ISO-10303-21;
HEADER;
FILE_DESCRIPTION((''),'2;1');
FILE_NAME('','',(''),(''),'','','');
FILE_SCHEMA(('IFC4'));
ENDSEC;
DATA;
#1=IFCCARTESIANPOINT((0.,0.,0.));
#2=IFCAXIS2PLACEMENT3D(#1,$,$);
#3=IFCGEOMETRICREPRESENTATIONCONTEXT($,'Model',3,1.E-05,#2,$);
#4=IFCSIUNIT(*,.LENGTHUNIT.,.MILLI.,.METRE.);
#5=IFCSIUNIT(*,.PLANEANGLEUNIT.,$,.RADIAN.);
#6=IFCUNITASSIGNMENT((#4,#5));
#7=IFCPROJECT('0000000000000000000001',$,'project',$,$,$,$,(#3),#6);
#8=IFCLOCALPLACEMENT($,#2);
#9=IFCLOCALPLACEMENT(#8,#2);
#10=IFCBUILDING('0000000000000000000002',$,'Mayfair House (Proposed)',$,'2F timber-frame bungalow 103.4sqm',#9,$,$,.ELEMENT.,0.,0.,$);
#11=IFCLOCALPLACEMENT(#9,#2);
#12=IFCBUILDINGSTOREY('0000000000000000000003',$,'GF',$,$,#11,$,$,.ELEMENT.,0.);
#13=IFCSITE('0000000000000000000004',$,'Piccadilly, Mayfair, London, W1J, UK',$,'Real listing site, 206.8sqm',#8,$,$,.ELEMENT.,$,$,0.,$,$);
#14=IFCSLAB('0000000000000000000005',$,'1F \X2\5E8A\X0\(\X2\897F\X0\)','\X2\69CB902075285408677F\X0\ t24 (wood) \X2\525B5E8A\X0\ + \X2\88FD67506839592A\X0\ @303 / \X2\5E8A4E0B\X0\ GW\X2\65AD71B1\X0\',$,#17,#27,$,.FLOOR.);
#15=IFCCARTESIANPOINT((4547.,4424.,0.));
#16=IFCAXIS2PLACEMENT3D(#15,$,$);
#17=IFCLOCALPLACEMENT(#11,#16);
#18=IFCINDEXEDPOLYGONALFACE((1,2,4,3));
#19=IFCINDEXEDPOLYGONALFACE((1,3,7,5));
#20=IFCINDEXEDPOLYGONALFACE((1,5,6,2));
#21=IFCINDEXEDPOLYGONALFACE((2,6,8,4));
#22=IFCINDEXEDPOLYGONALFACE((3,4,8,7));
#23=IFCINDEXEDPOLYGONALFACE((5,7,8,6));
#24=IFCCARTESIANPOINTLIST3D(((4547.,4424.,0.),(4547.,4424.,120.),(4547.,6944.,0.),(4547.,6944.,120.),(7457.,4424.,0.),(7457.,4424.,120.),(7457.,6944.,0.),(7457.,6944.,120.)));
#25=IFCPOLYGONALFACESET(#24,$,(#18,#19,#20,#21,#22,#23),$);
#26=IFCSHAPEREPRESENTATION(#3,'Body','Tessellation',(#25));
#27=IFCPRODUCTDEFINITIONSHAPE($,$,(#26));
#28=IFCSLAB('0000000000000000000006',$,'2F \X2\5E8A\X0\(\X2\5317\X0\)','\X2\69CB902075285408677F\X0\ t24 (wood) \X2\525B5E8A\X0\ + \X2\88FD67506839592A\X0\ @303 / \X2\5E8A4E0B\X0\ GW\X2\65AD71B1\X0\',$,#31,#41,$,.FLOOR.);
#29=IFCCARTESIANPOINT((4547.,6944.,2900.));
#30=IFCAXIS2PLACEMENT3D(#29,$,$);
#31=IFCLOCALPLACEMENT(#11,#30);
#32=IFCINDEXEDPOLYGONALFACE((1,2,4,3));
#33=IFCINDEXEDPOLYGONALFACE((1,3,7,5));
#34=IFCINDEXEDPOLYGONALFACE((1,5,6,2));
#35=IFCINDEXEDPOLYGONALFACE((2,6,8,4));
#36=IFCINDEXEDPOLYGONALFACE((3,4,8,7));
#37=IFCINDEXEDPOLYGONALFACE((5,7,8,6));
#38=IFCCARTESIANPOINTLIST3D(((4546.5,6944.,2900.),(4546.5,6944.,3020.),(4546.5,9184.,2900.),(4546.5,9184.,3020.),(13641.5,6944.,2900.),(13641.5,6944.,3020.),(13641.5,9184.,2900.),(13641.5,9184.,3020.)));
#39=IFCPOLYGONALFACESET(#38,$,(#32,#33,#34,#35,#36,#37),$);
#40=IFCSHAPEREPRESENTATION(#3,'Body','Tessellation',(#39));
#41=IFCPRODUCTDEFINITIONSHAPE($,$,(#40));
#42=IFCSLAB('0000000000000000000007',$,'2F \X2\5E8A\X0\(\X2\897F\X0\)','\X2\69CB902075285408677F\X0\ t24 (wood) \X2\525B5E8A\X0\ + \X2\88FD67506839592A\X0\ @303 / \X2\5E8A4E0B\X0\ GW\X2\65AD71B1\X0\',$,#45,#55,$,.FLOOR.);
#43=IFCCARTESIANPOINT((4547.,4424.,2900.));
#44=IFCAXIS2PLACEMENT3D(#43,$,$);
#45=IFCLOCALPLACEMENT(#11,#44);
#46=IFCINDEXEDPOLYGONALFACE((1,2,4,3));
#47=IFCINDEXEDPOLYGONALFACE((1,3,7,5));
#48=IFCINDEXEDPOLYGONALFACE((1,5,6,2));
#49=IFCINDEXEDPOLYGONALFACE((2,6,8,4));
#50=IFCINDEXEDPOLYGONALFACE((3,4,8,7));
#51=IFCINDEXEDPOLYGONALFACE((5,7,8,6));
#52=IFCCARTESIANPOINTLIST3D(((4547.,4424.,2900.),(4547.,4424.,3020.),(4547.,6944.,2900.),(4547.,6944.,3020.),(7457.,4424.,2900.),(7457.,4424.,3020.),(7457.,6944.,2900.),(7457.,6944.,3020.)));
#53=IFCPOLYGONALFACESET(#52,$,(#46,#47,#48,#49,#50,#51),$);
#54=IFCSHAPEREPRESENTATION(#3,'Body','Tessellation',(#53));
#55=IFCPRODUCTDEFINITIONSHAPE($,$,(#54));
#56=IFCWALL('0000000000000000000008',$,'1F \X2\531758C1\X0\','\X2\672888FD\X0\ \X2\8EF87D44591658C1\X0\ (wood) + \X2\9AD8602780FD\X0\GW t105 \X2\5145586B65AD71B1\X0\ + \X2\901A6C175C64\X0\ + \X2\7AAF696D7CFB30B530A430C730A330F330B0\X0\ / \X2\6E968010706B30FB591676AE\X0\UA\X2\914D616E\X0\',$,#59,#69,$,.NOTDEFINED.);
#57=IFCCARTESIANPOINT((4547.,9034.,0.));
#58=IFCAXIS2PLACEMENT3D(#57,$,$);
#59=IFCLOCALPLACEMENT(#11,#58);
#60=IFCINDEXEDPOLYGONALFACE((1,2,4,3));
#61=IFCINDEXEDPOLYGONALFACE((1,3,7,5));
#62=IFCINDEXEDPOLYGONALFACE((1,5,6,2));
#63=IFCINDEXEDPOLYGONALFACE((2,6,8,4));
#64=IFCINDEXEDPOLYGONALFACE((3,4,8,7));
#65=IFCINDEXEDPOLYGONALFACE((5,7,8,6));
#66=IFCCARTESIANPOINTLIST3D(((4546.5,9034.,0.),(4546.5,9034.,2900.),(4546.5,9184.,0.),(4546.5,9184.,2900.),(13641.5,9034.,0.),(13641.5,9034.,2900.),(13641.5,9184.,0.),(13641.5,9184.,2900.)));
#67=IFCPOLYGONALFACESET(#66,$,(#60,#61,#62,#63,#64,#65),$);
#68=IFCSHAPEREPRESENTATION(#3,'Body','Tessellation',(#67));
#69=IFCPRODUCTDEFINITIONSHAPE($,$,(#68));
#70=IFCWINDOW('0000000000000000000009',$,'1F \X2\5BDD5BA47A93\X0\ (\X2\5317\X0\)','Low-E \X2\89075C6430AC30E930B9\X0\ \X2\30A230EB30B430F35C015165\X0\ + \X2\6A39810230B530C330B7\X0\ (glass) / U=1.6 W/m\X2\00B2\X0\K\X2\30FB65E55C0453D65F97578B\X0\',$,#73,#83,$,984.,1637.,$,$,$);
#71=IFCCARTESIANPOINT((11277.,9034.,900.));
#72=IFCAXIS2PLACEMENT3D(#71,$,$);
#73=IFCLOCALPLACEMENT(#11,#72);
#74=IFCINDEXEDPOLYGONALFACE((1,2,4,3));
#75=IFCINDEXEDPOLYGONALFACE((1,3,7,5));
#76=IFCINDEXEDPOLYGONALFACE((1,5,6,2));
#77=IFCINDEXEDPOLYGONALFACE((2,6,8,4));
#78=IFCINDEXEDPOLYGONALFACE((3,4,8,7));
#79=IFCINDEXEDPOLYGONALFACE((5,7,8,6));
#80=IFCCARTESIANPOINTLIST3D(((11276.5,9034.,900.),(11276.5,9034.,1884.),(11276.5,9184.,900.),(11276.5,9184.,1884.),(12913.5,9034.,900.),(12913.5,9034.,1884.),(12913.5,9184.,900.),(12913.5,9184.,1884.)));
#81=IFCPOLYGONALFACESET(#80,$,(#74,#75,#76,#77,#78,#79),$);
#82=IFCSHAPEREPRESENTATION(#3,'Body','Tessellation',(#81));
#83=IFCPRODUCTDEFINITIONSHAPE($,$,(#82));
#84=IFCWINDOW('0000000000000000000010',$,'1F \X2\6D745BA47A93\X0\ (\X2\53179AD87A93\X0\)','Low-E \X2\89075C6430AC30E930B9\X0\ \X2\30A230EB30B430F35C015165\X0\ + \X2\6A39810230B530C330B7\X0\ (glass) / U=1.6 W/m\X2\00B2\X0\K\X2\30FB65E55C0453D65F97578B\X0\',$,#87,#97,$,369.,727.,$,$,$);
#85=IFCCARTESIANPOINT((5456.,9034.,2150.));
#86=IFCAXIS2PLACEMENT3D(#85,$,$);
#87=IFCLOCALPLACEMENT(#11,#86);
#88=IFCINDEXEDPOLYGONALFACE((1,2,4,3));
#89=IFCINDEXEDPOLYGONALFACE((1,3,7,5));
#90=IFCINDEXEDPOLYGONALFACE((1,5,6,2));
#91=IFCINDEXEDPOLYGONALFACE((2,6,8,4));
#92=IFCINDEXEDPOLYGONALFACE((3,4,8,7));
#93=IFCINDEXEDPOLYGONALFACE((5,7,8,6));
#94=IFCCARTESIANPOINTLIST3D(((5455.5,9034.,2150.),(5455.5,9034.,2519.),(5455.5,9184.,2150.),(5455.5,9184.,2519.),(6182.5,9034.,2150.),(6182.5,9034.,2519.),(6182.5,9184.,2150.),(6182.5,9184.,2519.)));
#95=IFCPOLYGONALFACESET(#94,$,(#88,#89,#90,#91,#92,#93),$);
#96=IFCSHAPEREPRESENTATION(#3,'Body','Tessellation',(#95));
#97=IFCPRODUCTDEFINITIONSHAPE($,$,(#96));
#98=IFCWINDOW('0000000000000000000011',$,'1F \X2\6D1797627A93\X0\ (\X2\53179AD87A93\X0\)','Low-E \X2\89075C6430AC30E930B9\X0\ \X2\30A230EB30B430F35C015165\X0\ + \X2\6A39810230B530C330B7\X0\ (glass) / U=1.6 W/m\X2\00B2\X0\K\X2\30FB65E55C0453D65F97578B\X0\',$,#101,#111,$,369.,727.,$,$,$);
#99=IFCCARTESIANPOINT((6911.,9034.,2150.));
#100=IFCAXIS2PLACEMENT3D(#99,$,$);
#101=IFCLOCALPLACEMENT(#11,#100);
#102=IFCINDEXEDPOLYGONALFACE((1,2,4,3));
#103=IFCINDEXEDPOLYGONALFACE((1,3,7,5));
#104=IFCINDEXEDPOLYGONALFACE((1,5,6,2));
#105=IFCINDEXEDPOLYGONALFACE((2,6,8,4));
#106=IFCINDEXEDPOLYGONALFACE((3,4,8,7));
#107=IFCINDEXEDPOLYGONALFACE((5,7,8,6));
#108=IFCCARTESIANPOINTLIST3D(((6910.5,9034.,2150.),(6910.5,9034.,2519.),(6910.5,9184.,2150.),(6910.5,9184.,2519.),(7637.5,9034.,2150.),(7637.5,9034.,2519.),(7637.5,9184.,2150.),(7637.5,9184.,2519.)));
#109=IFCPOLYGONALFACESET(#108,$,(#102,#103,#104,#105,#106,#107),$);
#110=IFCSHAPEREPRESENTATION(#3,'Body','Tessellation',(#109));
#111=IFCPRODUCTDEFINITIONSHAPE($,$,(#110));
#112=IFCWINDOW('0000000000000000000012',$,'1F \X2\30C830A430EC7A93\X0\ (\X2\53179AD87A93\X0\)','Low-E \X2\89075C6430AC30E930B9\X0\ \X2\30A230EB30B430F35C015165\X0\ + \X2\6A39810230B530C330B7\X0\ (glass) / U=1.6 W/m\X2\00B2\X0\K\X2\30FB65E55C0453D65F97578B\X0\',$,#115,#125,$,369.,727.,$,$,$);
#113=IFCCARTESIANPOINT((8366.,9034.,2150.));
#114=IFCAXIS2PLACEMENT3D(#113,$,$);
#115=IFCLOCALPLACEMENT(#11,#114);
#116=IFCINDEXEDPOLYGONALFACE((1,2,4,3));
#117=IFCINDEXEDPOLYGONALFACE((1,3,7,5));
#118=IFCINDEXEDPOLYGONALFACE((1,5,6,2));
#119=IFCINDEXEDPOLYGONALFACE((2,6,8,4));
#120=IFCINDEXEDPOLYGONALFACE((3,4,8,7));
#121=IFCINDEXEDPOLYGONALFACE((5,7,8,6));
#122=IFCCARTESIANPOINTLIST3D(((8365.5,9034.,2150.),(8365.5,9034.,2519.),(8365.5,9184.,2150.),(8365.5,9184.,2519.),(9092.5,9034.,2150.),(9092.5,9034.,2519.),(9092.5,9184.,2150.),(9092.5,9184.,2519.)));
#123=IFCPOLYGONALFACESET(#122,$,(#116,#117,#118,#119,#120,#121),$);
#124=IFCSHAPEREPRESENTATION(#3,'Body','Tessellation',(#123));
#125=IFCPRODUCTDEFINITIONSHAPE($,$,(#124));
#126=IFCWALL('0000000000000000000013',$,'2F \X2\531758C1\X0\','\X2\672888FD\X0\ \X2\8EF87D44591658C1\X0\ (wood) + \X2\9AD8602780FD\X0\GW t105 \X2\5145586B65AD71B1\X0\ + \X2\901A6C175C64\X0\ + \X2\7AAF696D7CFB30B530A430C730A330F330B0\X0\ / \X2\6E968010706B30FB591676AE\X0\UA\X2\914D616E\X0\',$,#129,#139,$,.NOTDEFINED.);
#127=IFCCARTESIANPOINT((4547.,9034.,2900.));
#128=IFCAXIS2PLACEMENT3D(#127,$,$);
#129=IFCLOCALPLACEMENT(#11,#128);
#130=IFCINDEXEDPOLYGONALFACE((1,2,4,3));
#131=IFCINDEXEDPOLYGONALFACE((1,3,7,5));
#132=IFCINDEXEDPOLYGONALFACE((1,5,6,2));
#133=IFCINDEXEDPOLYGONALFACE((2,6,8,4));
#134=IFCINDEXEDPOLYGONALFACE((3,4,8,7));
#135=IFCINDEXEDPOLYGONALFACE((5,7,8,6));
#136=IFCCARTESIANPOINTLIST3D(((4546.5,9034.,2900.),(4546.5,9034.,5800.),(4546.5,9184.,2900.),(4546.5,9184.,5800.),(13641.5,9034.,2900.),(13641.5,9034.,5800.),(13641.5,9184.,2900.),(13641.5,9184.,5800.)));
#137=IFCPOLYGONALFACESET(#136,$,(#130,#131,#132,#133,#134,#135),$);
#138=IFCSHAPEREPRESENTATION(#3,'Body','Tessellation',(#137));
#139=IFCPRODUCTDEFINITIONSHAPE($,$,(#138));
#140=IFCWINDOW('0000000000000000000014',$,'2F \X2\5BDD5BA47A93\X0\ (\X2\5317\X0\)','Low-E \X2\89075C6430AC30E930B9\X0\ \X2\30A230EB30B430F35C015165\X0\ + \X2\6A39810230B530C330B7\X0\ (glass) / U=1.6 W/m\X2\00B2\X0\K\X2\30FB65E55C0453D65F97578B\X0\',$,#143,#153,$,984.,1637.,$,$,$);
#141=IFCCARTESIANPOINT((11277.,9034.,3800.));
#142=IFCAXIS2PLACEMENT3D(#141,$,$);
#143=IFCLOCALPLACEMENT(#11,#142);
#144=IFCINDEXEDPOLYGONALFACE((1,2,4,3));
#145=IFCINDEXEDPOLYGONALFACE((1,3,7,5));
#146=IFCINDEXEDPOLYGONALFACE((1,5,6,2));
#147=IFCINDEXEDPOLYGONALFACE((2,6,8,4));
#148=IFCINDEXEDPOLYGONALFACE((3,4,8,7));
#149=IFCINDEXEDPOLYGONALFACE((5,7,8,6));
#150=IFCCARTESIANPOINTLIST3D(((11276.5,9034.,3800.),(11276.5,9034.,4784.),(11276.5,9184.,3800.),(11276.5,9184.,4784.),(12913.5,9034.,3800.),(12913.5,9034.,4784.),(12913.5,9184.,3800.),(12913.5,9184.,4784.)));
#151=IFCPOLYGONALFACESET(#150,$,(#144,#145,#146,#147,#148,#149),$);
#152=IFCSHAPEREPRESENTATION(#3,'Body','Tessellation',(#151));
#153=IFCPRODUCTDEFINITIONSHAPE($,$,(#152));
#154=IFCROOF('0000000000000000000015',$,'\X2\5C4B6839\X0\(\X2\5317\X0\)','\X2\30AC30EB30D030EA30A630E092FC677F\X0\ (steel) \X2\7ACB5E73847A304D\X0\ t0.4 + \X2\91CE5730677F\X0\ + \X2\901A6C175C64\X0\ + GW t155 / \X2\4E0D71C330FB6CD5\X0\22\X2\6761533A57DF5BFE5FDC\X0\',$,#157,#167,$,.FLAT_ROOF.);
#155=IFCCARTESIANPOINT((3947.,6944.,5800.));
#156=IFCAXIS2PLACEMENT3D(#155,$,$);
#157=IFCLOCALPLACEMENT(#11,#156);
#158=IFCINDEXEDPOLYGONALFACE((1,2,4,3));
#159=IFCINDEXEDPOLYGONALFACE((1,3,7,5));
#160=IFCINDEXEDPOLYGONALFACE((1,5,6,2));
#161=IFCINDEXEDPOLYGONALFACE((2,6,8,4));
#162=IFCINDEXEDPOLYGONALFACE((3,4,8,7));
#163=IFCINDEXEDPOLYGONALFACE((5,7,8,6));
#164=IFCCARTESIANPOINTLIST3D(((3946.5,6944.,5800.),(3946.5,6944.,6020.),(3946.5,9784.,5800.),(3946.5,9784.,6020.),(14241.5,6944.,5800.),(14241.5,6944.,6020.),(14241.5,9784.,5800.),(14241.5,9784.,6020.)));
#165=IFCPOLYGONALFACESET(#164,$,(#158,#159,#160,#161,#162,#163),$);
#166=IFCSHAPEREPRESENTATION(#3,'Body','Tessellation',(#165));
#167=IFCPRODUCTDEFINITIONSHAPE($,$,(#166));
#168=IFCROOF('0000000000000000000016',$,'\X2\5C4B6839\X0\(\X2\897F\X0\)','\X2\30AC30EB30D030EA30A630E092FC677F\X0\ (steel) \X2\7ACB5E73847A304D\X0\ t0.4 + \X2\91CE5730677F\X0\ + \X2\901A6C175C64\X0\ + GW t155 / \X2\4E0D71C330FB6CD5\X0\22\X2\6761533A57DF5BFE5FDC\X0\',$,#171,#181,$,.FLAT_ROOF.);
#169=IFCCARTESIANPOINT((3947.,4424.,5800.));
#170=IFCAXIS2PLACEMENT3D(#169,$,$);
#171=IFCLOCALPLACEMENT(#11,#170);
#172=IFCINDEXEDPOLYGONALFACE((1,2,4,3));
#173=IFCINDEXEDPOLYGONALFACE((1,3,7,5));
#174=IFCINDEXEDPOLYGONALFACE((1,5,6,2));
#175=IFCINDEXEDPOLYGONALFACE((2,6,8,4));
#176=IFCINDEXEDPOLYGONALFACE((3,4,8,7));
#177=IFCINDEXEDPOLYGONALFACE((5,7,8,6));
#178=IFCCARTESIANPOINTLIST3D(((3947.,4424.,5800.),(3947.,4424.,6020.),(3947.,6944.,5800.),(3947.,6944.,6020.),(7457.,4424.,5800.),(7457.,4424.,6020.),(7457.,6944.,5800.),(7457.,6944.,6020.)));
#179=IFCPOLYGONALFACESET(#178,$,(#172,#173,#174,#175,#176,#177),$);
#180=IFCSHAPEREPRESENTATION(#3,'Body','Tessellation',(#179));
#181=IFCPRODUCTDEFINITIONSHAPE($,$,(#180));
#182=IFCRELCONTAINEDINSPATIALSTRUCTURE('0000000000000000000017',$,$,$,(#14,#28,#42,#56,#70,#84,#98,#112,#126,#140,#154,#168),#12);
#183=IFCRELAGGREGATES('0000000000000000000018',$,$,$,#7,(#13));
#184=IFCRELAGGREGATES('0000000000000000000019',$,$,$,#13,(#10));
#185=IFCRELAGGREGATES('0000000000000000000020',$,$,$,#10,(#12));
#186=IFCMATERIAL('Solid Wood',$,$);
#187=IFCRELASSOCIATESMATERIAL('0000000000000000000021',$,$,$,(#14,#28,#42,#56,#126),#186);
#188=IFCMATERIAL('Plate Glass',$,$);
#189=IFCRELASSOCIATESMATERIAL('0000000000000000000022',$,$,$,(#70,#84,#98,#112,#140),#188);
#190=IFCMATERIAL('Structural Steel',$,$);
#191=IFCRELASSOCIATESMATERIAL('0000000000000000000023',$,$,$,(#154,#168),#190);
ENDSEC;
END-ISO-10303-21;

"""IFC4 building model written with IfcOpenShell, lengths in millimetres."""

from ifc_helpers import new_model, si_unit, frame, frame_2d, origin, place, context, project, spatial, rectangle, extrude, material, element, fill, save


model = new_model("IFC4")

# Units and contexts
model_context = context("Model", 3, precision=1e-05, world=origin())
ifc_project = project(units=[si_unit("LENGTHUNIT", "METRE", prefix="MILLI"), si_unit("PLANEANGLEUNIT", "RADIAN")], contexts=[model_context])

# Site, building, storey
site_placement = place(None, origin())
site = spatial("IfcSite", under=ifc_project, at=site_placement, Name="Piccadilly, Mayfair, London, W1J, UK", ObjectType="Real listing site, 206.8sqm", CompositionType="ELEMENT", RefElevation=0.0)
building_placement = place(site_placement, origin())
building = spatial("IfcBuilding", under=site, at=building_placement, Name="Mayfair House (Proposed)", ObjectType="2F timber-frame bungalow 103.4sqm", CompositionType="ELEMENT", ElevationOfRefHeight=0.0, ElevationOfTerrain=0.0)
storey_placement = place(building_placement, origin())
storey = spatial("IfcBuildingStorey", under=building, at=storey_placement, Name="GF", CompositionType="ELEMENT", Elevation=0.0)

# Slabs
ifc_material_1 = material(Name="Solid Wood")
slab_1_placement = place(storey_placement, frame((4547.0, 4424.0, 0.0)))
element("IfcSlab", 1, at=slab_1_placement, inside=storey, material=ifc_material_1, Name="1F 床(西)", Description="構造用合板 t24 (wood) 剛床 + 製材根太 @303 / 床下 GW断熱", PredefinedType="FLOOR", context=model_context, shape_type="SweptSolid", body=[
    extrude(rectangle(XDim=2910.0, YDim=2520.0, at=frame_2d((1455.0, 1260.0))), frame((4547.0, 4424.0, 0.0)), (0.0, 0.0, 1.0), 120.0),
])
slab_2_placement = place(storey_placement, frame((4547.0, 6944.0, 2900.0)))
element("IfcSlab", 2, at=slab_2_placement, inside=storey, material=ifc_material_1, Name="2F 床(北)", Description="構造用合板 t24 (wood) 剛床 + 製材根太 @303 / 床下 GW断熱", PredefinedType="FLOOR", context=model_context, shape_type="SweptSolid", body=[
    extrude(rectangle(XDim=9095.0, YDim=2240.0, at=frame_2d((4547.0, 1120.0))), frame((4547.0, 6944.0, 2900.0)), (0.0, 0.0, 1.0), 120.0),
])
slab_3_placement = place(storey_placement, frame((4547.0, 4424.0, 2900.0)))
element("IfcSlab", 3, at=slab_3_placement, inside=storey, material=ifc_material_1, Name="2F 床(西)", Description="構造用合板 t24 (wood) 剛床 + 製材根太 @303 / 床下 GW断熱", PredefinedType="FLOOR", context=model_context, shape_type="SweptSolid", body=[
    extrude(rectangle(XDim=2910.0, YDim=2520.0, at=frame_2d((1455.0, 1260.0))), frame((4547.0, 4424.0, 2900.0)), (0.0, 0.0, 1.0), 120.0),
])

# Wall, openings, windows
wall_1_placement = place(storey_placement, frame((4547.0, 9034.0, 0.0)))
wall_1 = element("IfcWall", 4, at=wall_1_placement, inside=storey, material=ifc_material_1, Name="1F 北壁", Description="木製 軸組外壁 (wood) + 高性能GW t105 充填断熱 + 通気層 + 窯業系サイディング / 準耐火・外皮UA配慮", PredefinedType="NOTDEFINED", context=model_context, shape_type="SweptSolid", body=[
    extrude(rectangle(XDim=9095.0, YDim=150.0, at=frame_2d((4547.0, 75.0))), frame((4547.0, 9034.0, 0.0)), (0.0, 0.0, 1.0), 2900.0),
])
opening_1_placement = place(storey_placement, frame((11277.0, 9034.0, 900.0)))
opening_1 = element("IfcOpeningElement", 5, at=opening_1_placement, cuts=wall_1, PredefinedType="NOTDEFINED", context=model_context, shape_type="SweptSolid", body=[
    extrude(rectangle(XDim=1637.0, YDim=150.0, at=frame_2d((818.0, 75.0))), frame((11277.0, 9034.0, 900.0)), (0.0, 0.0, 1.0), 984.0),
])
opening_2_placement = place(storey_placement, frame((5456.0, 9034.0, 2150.0)))
opening_2 = element("IfcOpeningElement", 6, at=opening_2_placement, cuts=wall_1, PredefinedType="NOTDEFINED", context=model_context, shape_type="SweptSolid", body=[
    extrude(rectangle(XDim=727.0, YDim=150.0, at=frame_2d((363.0, 75.0))), frame((5456.0, 9034.0, 2150.0)), (0.0, 0.0, 1.0), 369.0),
])
opening_3_placement = place(storey_placement, frame((6911.0, 9034.0, 2150.0)))
opening_3 = element("IfcOpeningElement", 7, at=opening_3_placement, cuts=wall_1, PredefinedType="NOTDEFINED", context=model_context, shape_type="SweptSolid", body=[
    extrude(rectangle(XDim=727.0, YDim=150.0, at=frame_2d((363.0, 75.0))), frame((6911.0, 9034.0, 2150.0)), (0.0, 0.0, 1.0), 369.0),
])
opening_4_placement = place(storey_placement, frame((8366.0, 9034.0, 2150.0)))
opening_4 = element("IfcOpeningElement", 8, at=opening_4_placement, cuts=wall_1, PredefinedType="NOTDEFINED", context=model_context, shape_type="SweptSolid", body=[
    extrude(rectangle(XDim=727.0, YDim=150.0, at=frame_2d((363.0, 75.0))), frame((8366.0, 9034.0, 2150.0)), (0.0, 0.0, 1.0), 369.0),
])
ifc_material_2 = material(Name="Plate Glass")
window_1_placement = place(storey_placement, frame((11277.0, 9034.0, 900.0)))
window_1 = element("IfcWindow", 9, at=window_1_placement, inside=storey, material=ifc_material_2, Name="1F 寝室窓 (北)", Description="Low-E 複層ガラス アルゴン封入 + 樹脂サッシ (glass) / U=1.6 W/m²K・日射取得型", OverallHeight=984.0, OverallWidth=1637.0, context=model_context, shape_type="SweptSolid", body=[
    extrude(rectangle(XDim=1637.0, YDim=150.0, at=frame_2d((818.0, 75.0))), frame((11277.0, 9034.0, 900.0)), (0.0, 0.0, 1.0), 984.0),
])
fill(opening_1, window_1)
window_2_placement = place(storey_placement, frame((5456.0, 9034.0, 2150.0)))
window_2 = element("IfcWindow", 10, at=window_2_placement, inside=storey, material=ifc_material_2, Name="1F 浴室窓 (北高窓)", Description="Low-E 複層ガラス アルゴン封入 + 樹脂サッシ (glass) / U=1.6 W/m²K・日射取得型", OverallHeight=369.0, OverallWidth=727.0, context=model_context, shape_type="SweptSolid", body=[
    extrude(rectangle(XDim=727.0, YDim=150.0, at=frame_2d((363.0, 75.0))), frame((5456.0, 9034.0, 2150.0)), (0.0, 0.0, 1.0), 369.0),
])
fill(opening_2, window_2)
window_3_placement = place(storey_placement, frame((6911.0, 9034.0, 2150.0)))
window_3 = element("IfcWindow", 11, at=window_3_placement, inside=storey, material=ifc_material_2, Name="1F 洗面窓 (北高窓)", Description="Low-E 複層ガラス アルゴン封入 + 樹脂サッシ (glass) / U=1.6 W/m²K・日射取得型", OverallHeight=369.0, OverallWidth=727.0, context=model_context, shape_type="SweptSolid", body=[
    extrude(rectangle(XDim=727.0, YDim=150.0, at=frame_2d((363.0, 75.0))), frame((6911.0, 9034.0, 2150.0)), (0.0, 0.0, 1.0), 369.0),
])
fill(opening_3, window_3)
window_4_placement = place(storey_placement, frame((8366.0, 9034.0, 2150.0)))
window_4 = element("IfcWindow", 12, at=window_4_placement, inside=storey, material=ifc_material_2, Name="1F トイレ窓 (北高窓)", Description="Low-E 複層ガラス アルゴン封入 + 樹脂サッシ (glass) / U=1.6 W/m²K・日射取得型", OverallHeight=369.0, OverallWidth=727.0, context=model_context, shape_type="SweptSolid", body=[
    extrude(rectangle(XDim=727.0, YDim=150.0, at=frame_2d((363.0, 75.0))), frame((8366.0, 9034.0, 2150.0)), (0.0, 0.0, 1.0), 369.0),
])
fill(opening_4, window_4)

# Wall, opening, window
wall_2_placement = place(storey_placement, frame((4547.0, 9034.0, 2900.0)))
wall_2 = element("IfcWall", 13, at=wall_2_placement, inside=storey, material=ifc_material_1, Name="2F 北壁", Description="木製 軸組外壁 (wood) + 高性能GW t105 充填断熱 + 通気層 + 窯業系サイディング / 準耐火・外皮UA配慮", PredefinedType="NOTDEFINED", context=model_context, shape_type="SweptSolid", body=[
    extrude(rectangle(XDim=9095.0, YDim=150.0, at=frame_2d((4547.0, 75.0))), frame((4547.0, 9034.0, 2900.0)), (0.0, 0.0, 1.0), 2900.0),
])
opening_5_placement = place(storey_placement, frame((11277.0, 9034.0, 3800.0)))
opening_5 = element("IfcOpeningElement", 14, at=opening_5_placement, cuts=wall_2, PredefinedType="NOTDEFINED", context=model_context, shape_type="SweptSolid", body=[
    extrude(rectangle(XDim=1637.0, YDim=150.0, at=frame_2d((818.0, 75.0))), frame((11277.0, 9034.0, 3800.0)), (0.0, 0.0, 1.0), 984.0),
])
window_5_placement = place(storey_placement, frame((11277.0, 9034.0, 3800.0)))
window_5 = element("IfcWindow", 15, at=window_5_placement, inside=storey, material=ifc_material_2, Name="2F 寝室窓 (北)", Description="Low-E 複層ガラス アルゴン封入 + 樹脂サッシ (glass) / U=1.6 W/m²K・日射取得型", OverallHeight=984.0, OverallWidth=1637.0, context=model_context, shape_type="SweptSolid", body=[
    extrude(rectangle(XDim=1637.0, YDim=150.0, at=frame_2d((818.0, 75.0))), frame((11277.0, 9034.0, 3800.0)), (0.0, 0.0, 1.0), 984.0),
])
fill(opening_5, window_5)

# Roofs
ifc_material_3 = material(Name="Structural Steel")
for number, where, name in (
    (16, (3947.0, 6944.0, 5800.0), "屋根(北)"),
):
    element("IfcRoof", number, at=place(storey_placement, frame(where)), inside=storey, material=ifc_material_3, Name=name, Description="ガルバリウム鋼板 (steel) 立平葺き t0.4 + 野地板 + 通気層 + GW t155 / 不燃・法22条区域対応", PredefinedType="FLAT_ROOF", context=model_context, shape_type="SweptSolid", body=[
        extrude(rectangle(XDim=10295.0, YDim=2840.0, at=frame_2d((5147.0, 1420.0))), frame((3947.0, 6944.0, 5800.0)), (0.0, 0.0, 1.0), 220.0),
    ])
roof_placement = place(storey_placement, frame((3947.0, 4424.0, 5800.0)))
element("IfcRoof", 17, at=roof_placement, inside=storey, material=ifc_material_3, Name="屋根(西)", Description="ガルバリウム鋼板 (steel) 立平葺き t0.4 + 野地板 + 通気層 + GW t155 / 不燃・法22条区域対応", PredefinedType="FLAT_ROOF", context=model_context, shape_type="SweptSolid", body=[
    extrude(rectangle(XDim=3510.0, YDim=2520.0, at=frame_2d((1755.0, 1260.0))), frame((3947.0, 4424.0, 5800.0)), (0.0, 0.0, 1.0), 220.0),
])

save(model, "model.ifc")
